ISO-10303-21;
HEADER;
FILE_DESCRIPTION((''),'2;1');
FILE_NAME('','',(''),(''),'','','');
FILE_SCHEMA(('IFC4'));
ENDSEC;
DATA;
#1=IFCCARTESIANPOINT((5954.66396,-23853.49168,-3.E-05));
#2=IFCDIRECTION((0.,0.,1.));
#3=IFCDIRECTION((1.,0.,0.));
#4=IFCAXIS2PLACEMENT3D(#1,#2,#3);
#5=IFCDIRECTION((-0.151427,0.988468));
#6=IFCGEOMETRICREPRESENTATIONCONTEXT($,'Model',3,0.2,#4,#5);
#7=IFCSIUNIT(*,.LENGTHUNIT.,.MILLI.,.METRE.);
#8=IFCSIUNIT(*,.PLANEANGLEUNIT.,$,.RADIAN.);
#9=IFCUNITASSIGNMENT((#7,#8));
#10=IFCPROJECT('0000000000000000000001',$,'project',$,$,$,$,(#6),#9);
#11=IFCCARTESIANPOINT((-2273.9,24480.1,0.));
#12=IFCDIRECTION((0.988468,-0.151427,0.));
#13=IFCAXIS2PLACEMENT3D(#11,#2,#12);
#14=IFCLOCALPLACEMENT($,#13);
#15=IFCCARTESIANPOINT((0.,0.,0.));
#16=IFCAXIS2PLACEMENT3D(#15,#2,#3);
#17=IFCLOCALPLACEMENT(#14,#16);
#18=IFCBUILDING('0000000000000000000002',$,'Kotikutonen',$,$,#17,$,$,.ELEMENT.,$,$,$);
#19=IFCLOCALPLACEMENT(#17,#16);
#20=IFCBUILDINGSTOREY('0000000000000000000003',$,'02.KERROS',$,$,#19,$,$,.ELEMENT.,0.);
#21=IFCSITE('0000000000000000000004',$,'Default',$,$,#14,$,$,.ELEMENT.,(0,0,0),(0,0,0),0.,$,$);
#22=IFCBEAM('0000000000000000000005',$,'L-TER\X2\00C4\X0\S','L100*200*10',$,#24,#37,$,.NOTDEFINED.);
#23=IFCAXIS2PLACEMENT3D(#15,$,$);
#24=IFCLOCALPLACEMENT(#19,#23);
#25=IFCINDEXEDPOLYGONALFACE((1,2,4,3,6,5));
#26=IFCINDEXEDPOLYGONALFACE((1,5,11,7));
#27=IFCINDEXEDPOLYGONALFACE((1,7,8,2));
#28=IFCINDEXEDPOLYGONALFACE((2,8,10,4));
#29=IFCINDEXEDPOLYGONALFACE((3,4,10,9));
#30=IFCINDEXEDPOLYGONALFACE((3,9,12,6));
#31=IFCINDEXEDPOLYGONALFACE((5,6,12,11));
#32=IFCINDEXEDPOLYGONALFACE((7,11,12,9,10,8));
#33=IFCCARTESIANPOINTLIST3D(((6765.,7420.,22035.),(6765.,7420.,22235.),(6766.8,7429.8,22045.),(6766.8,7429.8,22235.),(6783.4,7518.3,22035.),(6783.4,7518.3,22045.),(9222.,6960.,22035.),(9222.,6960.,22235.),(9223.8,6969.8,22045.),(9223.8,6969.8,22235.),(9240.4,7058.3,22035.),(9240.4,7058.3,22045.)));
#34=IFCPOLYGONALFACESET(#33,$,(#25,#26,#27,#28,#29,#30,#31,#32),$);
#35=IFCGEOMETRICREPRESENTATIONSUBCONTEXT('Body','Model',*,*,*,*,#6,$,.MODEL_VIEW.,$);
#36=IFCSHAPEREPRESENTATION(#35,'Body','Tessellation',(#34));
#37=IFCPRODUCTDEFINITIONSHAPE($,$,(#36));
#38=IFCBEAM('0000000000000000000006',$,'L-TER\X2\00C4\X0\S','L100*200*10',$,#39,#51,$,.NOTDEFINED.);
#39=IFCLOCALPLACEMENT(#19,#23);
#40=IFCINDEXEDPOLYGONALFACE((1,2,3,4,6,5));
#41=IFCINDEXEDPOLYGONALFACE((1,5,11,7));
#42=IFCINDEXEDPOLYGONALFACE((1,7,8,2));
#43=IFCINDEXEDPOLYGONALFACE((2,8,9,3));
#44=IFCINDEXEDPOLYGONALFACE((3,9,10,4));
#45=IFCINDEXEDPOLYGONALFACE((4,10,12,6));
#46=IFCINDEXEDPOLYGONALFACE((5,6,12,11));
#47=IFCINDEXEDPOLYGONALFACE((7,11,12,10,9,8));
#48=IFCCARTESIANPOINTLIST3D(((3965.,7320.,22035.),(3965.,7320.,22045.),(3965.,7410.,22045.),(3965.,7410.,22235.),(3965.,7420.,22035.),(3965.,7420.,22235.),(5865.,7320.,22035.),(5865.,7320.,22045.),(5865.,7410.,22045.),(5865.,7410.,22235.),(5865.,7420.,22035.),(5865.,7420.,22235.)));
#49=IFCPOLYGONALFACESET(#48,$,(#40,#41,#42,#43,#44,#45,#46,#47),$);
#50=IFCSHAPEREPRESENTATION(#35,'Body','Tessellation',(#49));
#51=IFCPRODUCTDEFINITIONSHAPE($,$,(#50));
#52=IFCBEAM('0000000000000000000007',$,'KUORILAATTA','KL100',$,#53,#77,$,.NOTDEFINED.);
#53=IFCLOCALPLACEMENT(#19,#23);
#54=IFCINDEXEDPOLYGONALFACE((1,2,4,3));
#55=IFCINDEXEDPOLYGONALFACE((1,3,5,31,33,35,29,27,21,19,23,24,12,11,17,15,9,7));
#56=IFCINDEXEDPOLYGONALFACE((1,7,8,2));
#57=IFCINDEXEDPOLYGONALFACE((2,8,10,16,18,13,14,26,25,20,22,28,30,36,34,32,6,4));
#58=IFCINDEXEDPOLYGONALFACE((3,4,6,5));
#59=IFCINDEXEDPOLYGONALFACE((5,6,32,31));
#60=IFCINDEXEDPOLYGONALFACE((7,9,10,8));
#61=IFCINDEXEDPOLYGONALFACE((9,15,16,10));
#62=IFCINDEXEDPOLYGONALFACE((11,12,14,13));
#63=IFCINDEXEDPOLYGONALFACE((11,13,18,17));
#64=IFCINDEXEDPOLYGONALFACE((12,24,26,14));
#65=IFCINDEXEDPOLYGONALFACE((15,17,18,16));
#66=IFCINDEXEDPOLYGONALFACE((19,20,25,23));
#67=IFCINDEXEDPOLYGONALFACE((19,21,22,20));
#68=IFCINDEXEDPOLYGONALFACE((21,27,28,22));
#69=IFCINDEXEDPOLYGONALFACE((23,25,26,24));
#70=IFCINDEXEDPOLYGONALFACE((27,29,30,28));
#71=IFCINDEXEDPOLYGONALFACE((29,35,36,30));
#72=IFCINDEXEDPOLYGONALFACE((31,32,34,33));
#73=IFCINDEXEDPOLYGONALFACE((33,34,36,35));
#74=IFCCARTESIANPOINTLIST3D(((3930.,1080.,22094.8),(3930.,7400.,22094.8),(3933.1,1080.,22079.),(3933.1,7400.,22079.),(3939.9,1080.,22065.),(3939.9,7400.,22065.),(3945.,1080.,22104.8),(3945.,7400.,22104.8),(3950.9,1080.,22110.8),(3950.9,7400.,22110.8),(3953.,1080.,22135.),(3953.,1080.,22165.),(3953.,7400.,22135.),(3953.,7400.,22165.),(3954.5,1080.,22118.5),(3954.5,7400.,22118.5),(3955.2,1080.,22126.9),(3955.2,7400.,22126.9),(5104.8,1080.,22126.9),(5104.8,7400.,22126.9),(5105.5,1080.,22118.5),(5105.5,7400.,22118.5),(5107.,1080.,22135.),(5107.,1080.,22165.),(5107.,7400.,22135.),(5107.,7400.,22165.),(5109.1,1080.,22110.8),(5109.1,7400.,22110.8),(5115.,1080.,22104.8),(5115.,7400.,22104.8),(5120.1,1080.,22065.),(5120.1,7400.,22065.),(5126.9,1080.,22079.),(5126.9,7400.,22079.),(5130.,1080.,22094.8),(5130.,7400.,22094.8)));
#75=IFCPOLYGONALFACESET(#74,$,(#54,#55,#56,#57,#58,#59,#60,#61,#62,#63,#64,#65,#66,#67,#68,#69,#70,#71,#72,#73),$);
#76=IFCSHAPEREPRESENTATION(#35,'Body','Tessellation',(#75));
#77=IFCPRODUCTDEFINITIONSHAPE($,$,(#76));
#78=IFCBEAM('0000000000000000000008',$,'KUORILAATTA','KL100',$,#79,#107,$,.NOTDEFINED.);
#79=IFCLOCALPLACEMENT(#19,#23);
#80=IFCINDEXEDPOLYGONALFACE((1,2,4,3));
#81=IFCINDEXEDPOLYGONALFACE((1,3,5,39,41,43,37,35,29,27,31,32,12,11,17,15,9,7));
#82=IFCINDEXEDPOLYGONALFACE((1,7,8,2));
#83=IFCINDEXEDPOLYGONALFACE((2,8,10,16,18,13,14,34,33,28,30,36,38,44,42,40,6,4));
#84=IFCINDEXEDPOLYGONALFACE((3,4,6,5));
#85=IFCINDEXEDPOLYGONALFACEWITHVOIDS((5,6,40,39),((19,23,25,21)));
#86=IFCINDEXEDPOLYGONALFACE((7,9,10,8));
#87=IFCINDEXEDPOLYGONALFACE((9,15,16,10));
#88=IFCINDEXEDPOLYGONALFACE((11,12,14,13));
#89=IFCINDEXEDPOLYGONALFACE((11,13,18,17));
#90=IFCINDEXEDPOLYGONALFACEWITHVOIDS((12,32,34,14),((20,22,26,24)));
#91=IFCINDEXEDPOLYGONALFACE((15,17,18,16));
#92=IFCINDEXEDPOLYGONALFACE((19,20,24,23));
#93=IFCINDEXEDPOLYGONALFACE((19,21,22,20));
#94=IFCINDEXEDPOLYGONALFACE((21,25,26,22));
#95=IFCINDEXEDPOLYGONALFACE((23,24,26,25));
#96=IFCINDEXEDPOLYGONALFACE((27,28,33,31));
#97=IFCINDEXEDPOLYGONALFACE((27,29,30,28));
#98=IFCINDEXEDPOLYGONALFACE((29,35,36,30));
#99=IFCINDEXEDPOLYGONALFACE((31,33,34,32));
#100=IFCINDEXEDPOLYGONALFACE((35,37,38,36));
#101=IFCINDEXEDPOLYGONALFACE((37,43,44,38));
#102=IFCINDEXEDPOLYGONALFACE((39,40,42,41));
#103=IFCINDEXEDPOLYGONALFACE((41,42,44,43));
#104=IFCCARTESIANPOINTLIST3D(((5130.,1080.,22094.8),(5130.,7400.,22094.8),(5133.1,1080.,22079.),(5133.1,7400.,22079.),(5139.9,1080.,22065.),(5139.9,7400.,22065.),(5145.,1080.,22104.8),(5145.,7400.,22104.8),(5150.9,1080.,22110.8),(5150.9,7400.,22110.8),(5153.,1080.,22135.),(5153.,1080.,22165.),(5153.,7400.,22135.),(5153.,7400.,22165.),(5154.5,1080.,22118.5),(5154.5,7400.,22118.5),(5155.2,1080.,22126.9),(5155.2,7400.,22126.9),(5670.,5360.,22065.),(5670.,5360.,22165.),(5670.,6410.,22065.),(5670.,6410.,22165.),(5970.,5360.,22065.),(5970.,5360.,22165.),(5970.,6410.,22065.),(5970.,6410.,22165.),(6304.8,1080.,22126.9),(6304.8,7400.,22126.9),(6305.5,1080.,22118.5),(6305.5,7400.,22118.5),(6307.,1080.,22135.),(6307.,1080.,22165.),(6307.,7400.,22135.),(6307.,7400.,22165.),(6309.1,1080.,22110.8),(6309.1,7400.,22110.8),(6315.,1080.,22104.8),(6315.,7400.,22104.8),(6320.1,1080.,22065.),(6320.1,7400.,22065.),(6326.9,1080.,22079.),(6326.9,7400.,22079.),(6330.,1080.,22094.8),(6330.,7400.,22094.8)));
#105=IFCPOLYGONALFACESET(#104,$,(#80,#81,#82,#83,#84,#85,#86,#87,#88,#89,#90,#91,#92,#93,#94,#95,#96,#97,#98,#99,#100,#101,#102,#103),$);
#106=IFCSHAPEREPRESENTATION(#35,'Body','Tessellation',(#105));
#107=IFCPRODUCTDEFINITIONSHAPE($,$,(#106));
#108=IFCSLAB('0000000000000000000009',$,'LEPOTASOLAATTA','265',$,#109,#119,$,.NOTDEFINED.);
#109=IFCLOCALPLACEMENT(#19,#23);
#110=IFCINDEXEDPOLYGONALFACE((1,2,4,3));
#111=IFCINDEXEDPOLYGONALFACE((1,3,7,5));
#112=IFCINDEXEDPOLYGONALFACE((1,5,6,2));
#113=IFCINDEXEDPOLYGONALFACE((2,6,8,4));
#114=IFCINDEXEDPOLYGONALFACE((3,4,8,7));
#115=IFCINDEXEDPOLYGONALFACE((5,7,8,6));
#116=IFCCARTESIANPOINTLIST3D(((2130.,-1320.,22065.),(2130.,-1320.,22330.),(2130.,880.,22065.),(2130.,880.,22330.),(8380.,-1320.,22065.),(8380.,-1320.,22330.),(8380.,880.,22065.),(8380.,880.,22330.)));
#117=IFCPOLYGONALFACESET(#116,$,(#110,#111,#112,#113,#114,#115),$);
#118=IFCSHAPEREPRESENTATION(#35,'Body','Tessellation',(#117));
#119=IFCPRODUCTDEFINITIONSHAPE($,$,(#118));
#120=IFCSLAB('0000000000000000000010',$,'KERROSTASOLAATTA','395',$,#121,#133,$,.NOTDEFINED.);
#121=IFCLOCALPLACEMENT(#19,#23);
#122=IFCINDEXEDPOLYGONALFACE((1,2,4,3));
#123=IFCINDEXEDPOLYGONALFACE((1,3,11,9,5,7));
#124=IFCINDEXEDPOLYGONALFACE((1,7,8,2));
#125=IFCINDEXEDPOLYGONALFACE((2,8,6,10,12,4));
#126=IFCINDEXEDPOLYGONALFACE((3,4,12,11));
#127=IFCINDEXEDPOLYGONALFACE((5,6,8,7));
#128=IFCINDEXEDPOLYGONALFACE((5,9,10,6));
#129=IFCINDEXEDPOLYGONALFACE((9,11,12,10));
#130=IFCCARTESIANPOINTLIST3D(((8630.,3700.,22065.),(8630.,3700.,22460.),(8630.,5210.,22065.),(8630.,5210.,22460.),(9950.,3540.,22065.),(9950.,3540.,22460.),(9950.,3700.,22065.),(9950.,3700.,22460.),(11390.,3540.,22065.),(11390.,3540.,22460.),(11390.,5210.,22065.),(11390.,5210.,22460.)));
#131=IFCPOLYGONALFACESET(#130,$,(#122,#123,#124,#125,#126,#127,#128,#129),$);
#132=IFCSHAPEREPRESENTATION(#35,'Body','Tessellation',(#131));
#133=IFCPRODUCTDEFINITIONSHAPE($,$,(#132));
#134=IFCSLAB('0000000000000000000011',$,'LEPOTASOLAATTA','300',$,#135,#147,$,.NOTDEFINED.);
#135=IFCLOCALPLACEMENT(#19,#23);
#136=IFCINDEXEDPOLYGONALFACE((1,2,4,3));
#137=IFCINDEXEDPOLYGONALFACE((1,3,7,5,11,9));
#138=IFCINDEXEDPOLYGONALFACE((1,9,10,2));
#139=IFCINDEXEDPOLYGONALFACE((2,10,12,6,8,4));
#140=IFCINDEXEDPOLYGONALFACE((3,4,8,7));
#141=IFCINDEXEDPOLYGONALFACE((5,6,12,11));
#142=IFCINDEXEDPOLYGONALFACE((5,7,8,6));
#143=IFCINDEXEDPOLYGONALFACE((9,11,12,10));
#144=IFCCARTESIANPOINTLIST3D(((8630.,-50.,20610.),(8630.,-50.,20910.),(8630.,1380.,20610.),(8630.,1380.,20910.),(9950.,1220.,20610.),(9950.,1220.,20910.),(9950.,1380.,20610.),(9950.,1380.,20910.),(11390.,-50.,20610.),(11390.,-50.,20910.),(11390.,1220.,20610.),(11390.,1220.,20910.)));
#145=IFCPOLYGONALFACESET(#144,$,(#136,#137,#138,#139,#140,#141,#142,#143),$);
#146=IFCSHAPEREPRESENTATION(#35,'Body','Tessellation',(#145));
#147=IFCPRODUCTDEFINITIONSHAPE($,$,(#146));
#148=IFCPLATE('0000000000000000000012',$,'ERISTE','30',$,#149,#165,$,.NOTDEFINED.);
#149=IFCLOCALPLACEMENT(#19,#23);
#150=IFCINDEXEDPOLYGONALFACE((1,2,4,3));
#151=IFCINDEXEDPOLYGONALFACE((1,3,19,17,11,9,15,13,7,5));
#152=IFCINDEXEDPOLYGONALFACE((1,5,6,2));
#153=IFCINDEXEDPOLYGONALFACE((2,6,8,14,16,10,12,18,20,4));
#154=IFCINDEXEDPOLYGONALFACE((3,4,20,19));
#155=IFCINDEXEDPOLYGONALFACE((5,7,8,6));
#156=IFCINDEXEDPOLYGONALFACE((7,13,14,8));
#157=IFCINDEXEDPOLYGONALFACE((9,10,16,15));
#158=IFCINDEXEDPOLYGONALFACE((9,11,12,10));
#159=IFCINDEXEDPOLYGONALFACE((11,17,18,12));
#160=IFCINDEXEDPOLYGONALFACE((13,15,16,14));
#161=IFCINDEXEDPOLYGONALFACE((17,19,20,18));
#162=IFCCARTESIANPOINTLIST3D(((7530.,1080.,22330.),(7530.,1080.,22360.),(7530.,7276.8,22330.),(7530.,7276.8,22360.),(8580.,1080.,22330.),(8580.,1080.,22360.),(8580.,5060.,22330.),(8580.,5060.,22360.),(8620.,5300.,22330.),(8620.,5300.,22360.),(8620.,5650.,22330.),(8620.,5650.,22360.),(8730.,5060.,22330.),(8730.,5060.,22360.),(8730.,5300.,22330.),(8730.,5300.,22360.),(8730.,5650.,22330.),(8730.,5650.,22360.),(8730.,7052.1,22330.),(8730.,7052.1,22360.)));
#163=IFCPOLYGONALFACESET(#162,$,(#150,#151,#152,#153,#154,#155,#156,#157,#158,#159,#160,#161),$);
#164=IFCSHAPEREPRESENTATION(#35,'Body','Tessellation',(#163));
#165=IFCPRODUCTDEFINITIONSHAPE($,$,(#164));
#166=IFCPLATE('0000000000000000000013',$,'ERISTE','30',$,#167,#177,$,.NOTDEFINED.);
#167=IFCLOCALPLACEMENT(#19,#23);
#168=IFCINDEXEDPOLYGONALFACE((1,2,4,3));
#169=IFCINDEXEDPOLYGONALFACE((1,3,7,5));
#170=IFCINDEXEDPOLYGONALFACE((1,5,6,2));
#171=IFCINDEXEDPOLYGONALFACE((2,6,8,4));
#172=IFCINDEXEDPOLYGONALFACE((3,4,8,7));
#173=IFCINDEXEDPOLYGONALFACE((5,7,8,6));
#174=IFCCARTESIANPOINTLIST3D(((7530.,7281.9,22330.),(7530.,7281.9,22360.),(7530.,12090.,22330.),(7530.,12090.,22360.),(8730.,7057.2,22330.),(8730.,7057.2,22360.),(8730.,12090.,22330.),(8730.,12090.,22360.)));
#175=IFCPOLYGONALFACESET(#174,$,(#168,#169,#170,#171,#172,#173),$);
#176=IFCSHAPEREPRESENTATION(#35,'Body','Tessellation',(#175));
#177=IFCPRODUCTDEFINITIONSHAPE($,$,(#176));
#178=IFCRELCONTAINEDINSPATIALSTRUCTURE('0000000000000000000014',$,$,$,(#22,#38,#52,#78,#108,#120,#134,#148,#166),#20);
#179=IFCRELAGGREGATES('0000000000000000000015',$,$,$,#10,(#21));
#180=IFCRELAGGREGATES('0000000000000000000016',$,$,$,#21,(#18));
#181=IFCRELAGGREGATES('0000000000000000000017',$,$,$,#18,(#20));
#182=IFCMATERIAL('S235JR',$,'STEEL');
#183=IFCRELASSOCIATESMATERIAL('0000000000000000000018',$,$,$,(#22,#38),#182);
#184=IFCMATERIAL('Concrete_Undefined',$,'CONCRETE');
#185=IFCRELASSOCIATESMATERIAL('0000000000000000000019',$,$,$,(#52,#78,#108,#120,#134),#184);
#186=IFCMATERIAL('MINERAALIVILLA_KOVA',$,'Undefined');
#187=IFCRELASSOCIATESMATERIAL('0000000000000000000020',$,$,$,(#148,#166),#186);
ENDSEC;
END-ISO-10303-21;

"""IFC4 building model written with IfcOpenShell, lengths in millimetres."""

from ifc_helpers import new_model, si_unit, direction, frame, origin_with_axes, place, context, subcontext, project, spatial, line, indexed_curve, outline, extrude, material, element, save


model = new_model("IFC4")

# Units and contexts
model_context = context("Model", 3, precision=0.2, world=frame((5954.66396, -23853.49168, -3e-05), z_axis=(0.0, 0.0, 1.0), x_axis=(1.0, 0.0, 0.0)), true_north=direction((-0.151427, 0.988468)))
body_context = subcontext(model_context, "Body", "Model", "MODEL_VIEW")
ifc_project = project(units=[si_unit("LENGTHUNIT", "METRE", prefix="MILLI"), si_unit("PLANEANGLEUNIT", "RADIAN")], contexts=[model_context])

# Site, building, storey
site_placement = place(None, frame((-2273.9, 24480.1, 0.0), z_axis=(0.0, 0.0, 1.0), x_axis=(0.988468, -0.151427, 0.0)))
site = spatial("IfcSite", under=ifc_project, at=site_placement, Name="Default", CompositionType="ELEMENT", RefLatitude=(0, 0, 0), RefLongitude=(0, 0, 0), RefElevation=0.0)
building_placement = place(site_placement, origin_with_axes())
building = spatial("IfcBuilding", under=site, at=building_placement, Name="Kotikutonen", CompositionType="ELEMENT")
storey_placement = place(building_placement, origin_with_axes())
storey = spatial("IfcBuildingStorey", under=building, at=storey_placement, Name="02.KERROS", CompositionType="ELEMENT", Elevation=0.0)

# Beams
ifc_material_1 = material(Name="S235JR", Category="STEEL")
beam_1_placement = place(storey_placement, frame((6774.2, 7469.1, 22135.0), z_axis=(0.0, 0.0, 1.0), x_axis=(0.982922, -0.184023, 0.0)))
element("IfcBeam", 1, at=beam_1_placement, inside=storey, material=ifc_material_1, Name="L-TERÄS", Description="L100*200*10", PredefinedType="NOTDEFINED", context=body_context, shape_type="SolidModel", body=[
    extrude(outline(indexed_curve([(-100.0, -50.0), (100.0, -50.0), (100.0, -40.0), (-90.0, -40.0), (-90.0, 50.0), (-100.0, 50.0)], segments=[line(1, 2, 3, 4, 5, 6, 1)])), frame((0.0, 0.0, 0.0), z_axis=(-1.0, 0.0, 0.0), x_axis=(0.0, 0.0, 1.0)), (0.0, 0.0, -1.0), 2499.7),
])
beam_2_placement = place(storey_placement, frame((5865.0, 7370.0, 22135.0), z_axis=(0.0, 0.0, 1.0), x_axis=(-1.0, 0.0, 0.0)))
element("IfcBeam", 2, at=beam_2_placement, inside=storey, material=ifc_material_1, Name="L-TERÄS", Description="L100*200*10", PredefinedType="NOTDEFINED", context=body_context, shape_type="SolidModel", body=[
    extrude(outline(indexed_curve([(-100.0, -50.0), (100.0, -50.0), (100.0, -40.0), (-90.0, -40.0), (-90.0, 50.0), (-100.0, 50.0)], segments=[line(1, 2, 3, 4, 5, 6, 1)])), frame((0.0, 0.0, 0.0), z_axis=(-1.0, 0.0, 0.0), x_axis=(0.0, 0.0, 1.0)), (0.0, 0.0, -1.0), 1900.0),
])
ifc_material_2 = material(Name="Concrete_Undefined", Category="CONCRETE")
beam_3_placement = place(storey_placement, frame((4530.0, 7400.0, 22115.0), z_axis=(-1.0, 0.0, 0.0), x_axis=(0.0, -1.0, 0.0)))
element("IfcBeam", 3, at=beam_3_placement, inside=storey, material=ifc_material_2, Name="KUORILAATTA", Description="KL100", PredefinedType="NOTDEFINED", context=body_context, shape_type="SolidModel", body=[
    extrude(outline(indexed_curve([(-596.9, -36.0), (-590.1, -50.0), (590.1, -50.0), (596.9, -36.0), (600.0, -20.2), (585.0, -10.2), (579.1, -4.2), (575.5, 3.5), (574.8, 11.9), (577.0, 20.0), (577.0, 50.0), (-577.0, 50.0), (-577.0, 20.0), (-574.8, 11.9), (-575.5, 3.5), (-579.1, -4.2), (-585.0, -10.2), (-600.0, -20.2)], segments=[line(1, 2, 3, 4, 5, 6, 7, 8, 9, 10, 11, 12, 13, 14, 15, 16, 17, 18, 1)])), frame((0.0, 0.0, 0.0), z_axis=(-1.0, 0.0, 0.0), x_axis=(0.0, 0.0, 1.0)), (0.0, 0.0, -1.0), 6320.0),
])

# Beam, voiding feature
beam_4_placement = place(storey_placement, frame((5730.0, 7400.0, 22115.0), z_axis=(-1.0, 0.0, 0.0), x_axis=(0.0, -1.0, 0.0)))
beam_4 = element("IfcBeam", 4, at=beam_4_placement, inside=storey, material=ifc_material_2, Name="KUORILAATTA", Description="KL100", PredefinedType="NOTDEFINED", context=body_context, shape_type="SolidModel", body=[
    extrude(outline(indexed_curve([(-596.9, -36.0), (-590.1, -50.0), (590.1, -50.0), (596.9, -36.0), (600.0, -20.2), (585.0, -10.2), (579.1, -4.2), (575.5, 3.5), (574.8, 11.9), (577.0, 20.0), (577.0, 50.0), (-577.0, 50.0), (-577.0, 20.0), (-574.8, 11.9), (-575.5, 3.5), (-579.1, -4.2), (-585.0, -10.2), (-600.0, -20.2)], segments=[line(1, 2, 3, 4, 5, 6, 7, 8, 9, 10, 11, 12, 13, 14, 15, 16, 17, 18, 1)])), frame((0.0, 0.0, 0.0), z_axis=(-1.0, 0.0, 0.0), x_axis=(0.0, 0.0, 1.0)), (0.0, 0.0, -1.0), 6320.0),
])
voiding_feature_1_placement = place(beam_4_placement, frame((990.0, 0.0, -240.0), z_axis=(0.0, 1.0, 0.0), x_axis=(0.0, 0.0, 1.0)))
element("IfcVoidingFeature", 5, at=voiding_feature_1_placement, cuts=beam_4, Name="Opening", PredefinedType="HOLE", context=body_context, shape_type="SolidModel", body=[
    extrude(outline(indexed_curve([(0.0, 0.0), (300.0, 0.0), (300.0, 1050.0), (0.0, 1050.0)], segments=[line(1, 2, 3, 4, 1)])), frame((0.0, 0.0, 125.0), z_axis=(0.0, 0.0, 1.0), x_axis=(1.0, 0.0, 0.0)), (0.0, 0.0, -1.0), 250.0),
])

# Slabs
slab_1_placement = place(storey_placement, frame((2130.0, 880.0, 22197.5), z_axis=(0.0, 0.0, 1.0), x_axis=(0.0, -1.0, 0.0)))
element("IfcSlab", 6, at=slab_1_placement, inside=storey, material=ifc_material_2, Name="LEPOTASOLAATTA", Description="265", PredefinedType="NOTDEFINED", context=body_context, shape_type="SolidModel", body=[
    extrude(outline(indexed_curve([(0.0, 0.0), (2200.0, 0.0), (2200.0, 6250.0), (0.0, 6250.0)], segments=[line(1, 2, 3, 4, 1)])), frame((0.0, 0.0, 132.5), z_axis=(0.0, 0.0, 1.0), x_axis=(1.0, 0.0, 0.0)), (0.0, 0.0, -1.0), 265.0),
])
slab_2_placement = place(storey_placement, frame((8630.0, 5210.0, 22262.5), z_axis=(0.0, 0.0, 1.0), x_axis=(0.0, -1.0, 0.0)))
element("IfcSlab", 7, at=slab_2_placement, inside=storey, material=ifc_material_2, Name="KERROSTASOLAATTA", Description="395", PredefinedType="NOTDEFINED", context=body_context, shape_type="SolidModel", body=[
    extrude(outline(indexed_curve([(0.0, 0.0), (1510.0, 0.0), (1510.0, 1320.0), (1670.0, 1320.0), (1670.0, 2760.0), (0.0, 2760.0)], segments=[line(1, 2, 3, 4, 5, 6, 1)])), frame((0.0, 0.0, 197.5), z_axis=(0.0, 0.0, 1.0), x_axis=(1.0, 0.0, 0.0)), (0.0, 0.0, -1.0), 395.0),
])
slab_3_placement = place(storey_placement, frame((8630.0, 1380.0, 20760.0), z_axis=(0.0, 0.0, 1.0), x_axis=(0.0, -1.0, 0.0)))
element("IfcSlab", 8, at=slab_3_placement, inside=storey, material=ifc_material_2, Name="LEPOTASOLAATTA", Description="300", PredefinedType="NOTDEFINED", context=body_context, shape_type="SolidModel", body=[
    extrude(outline(indexed_curve([(0.0, 0.0), (1430.0, 0.0), (1430.0, 2760.0), (160.0, 2760.0), (160.0, 1320.0), (0.0, 1320.0)], segments=[line(1, 2, 3, 4, 5, 6, 1)])), frame((0.0, 0.0, 150.0), z_axis=(0.0, 0.0, 1.0), x_axis=(1.0, 0.0, 0.0)), (0.0, 0.0, -1.0), 300.0),
])

# Plates
ifc_material_3 = material(Name="MINERAALIVILLA_KOVA", Category="Undefined")
plate_1_placement = place(storey_placement, frame((7530.0, 1080.0, 22345.0), z_axis=(0.0, 0.0, 1.0), x_axis=(1.0, 0.0, 0.0)))
element("IfcPlate", 9, at=plate_1_placement, inside=storey, material=ifc_material_3, Name="ERISTE", Description="30", PredefinedType="NOTDEFINED", context=body_context, shape_type="SolidModel", body=[
    extrude(outline(indexed_curve([(0.0, 0.0), (1050.0, 0.0), (1050.0, 3980.0), (1200.0, 3980.0), (1200.0, 4220.0), (1090.0, 4220.0), (1090.0, 4570.0), (1200.0, 4570.0), (1200.0, 5972.1), (0.0, 6196.8)], segments=[line(1, 2, 3, 4, 5, 6, 7, 8, 9, 10, 1)])), frame((0.0, 0.0, 15.0), z_axis=(0.0, 0.0, 1.0), x_axis=(1.0, 0.0, 0.0)), (0.0, 0.0, -1.0), 30.0),
])
plate_2_placement = place(storey_placement, frame((7530.0, 7281.9, 22345.0), z_axis=(0.0, 0.0, 1.0), x_axis=(0.982922, -0.184023, 0.0)))
element("IfcPlate", 10, at=plate_2_placement, inside=storey, material=ifc_material_3, Name="ERISTE", Description="30", PredefinedType="NOTDEFINED", context=body_context, shape_type="SolidModel", body=[
    extrude(outline(indexed_curve([(0.0, 0.0), (1220.8, 0.0), (294.7, 4946.9), (-884.8, 4726.0)], segments=[line(1, 2, 3, 4, 1)])), frame((0.0, 0.0, 15.0), z_axis=(0.0, 0.0, 1.0), x_axis=(1.0, 0.0, 0.0)), (0.0, 0.0, -1.0), 30.0),
])

save(model, "model.ifc")
